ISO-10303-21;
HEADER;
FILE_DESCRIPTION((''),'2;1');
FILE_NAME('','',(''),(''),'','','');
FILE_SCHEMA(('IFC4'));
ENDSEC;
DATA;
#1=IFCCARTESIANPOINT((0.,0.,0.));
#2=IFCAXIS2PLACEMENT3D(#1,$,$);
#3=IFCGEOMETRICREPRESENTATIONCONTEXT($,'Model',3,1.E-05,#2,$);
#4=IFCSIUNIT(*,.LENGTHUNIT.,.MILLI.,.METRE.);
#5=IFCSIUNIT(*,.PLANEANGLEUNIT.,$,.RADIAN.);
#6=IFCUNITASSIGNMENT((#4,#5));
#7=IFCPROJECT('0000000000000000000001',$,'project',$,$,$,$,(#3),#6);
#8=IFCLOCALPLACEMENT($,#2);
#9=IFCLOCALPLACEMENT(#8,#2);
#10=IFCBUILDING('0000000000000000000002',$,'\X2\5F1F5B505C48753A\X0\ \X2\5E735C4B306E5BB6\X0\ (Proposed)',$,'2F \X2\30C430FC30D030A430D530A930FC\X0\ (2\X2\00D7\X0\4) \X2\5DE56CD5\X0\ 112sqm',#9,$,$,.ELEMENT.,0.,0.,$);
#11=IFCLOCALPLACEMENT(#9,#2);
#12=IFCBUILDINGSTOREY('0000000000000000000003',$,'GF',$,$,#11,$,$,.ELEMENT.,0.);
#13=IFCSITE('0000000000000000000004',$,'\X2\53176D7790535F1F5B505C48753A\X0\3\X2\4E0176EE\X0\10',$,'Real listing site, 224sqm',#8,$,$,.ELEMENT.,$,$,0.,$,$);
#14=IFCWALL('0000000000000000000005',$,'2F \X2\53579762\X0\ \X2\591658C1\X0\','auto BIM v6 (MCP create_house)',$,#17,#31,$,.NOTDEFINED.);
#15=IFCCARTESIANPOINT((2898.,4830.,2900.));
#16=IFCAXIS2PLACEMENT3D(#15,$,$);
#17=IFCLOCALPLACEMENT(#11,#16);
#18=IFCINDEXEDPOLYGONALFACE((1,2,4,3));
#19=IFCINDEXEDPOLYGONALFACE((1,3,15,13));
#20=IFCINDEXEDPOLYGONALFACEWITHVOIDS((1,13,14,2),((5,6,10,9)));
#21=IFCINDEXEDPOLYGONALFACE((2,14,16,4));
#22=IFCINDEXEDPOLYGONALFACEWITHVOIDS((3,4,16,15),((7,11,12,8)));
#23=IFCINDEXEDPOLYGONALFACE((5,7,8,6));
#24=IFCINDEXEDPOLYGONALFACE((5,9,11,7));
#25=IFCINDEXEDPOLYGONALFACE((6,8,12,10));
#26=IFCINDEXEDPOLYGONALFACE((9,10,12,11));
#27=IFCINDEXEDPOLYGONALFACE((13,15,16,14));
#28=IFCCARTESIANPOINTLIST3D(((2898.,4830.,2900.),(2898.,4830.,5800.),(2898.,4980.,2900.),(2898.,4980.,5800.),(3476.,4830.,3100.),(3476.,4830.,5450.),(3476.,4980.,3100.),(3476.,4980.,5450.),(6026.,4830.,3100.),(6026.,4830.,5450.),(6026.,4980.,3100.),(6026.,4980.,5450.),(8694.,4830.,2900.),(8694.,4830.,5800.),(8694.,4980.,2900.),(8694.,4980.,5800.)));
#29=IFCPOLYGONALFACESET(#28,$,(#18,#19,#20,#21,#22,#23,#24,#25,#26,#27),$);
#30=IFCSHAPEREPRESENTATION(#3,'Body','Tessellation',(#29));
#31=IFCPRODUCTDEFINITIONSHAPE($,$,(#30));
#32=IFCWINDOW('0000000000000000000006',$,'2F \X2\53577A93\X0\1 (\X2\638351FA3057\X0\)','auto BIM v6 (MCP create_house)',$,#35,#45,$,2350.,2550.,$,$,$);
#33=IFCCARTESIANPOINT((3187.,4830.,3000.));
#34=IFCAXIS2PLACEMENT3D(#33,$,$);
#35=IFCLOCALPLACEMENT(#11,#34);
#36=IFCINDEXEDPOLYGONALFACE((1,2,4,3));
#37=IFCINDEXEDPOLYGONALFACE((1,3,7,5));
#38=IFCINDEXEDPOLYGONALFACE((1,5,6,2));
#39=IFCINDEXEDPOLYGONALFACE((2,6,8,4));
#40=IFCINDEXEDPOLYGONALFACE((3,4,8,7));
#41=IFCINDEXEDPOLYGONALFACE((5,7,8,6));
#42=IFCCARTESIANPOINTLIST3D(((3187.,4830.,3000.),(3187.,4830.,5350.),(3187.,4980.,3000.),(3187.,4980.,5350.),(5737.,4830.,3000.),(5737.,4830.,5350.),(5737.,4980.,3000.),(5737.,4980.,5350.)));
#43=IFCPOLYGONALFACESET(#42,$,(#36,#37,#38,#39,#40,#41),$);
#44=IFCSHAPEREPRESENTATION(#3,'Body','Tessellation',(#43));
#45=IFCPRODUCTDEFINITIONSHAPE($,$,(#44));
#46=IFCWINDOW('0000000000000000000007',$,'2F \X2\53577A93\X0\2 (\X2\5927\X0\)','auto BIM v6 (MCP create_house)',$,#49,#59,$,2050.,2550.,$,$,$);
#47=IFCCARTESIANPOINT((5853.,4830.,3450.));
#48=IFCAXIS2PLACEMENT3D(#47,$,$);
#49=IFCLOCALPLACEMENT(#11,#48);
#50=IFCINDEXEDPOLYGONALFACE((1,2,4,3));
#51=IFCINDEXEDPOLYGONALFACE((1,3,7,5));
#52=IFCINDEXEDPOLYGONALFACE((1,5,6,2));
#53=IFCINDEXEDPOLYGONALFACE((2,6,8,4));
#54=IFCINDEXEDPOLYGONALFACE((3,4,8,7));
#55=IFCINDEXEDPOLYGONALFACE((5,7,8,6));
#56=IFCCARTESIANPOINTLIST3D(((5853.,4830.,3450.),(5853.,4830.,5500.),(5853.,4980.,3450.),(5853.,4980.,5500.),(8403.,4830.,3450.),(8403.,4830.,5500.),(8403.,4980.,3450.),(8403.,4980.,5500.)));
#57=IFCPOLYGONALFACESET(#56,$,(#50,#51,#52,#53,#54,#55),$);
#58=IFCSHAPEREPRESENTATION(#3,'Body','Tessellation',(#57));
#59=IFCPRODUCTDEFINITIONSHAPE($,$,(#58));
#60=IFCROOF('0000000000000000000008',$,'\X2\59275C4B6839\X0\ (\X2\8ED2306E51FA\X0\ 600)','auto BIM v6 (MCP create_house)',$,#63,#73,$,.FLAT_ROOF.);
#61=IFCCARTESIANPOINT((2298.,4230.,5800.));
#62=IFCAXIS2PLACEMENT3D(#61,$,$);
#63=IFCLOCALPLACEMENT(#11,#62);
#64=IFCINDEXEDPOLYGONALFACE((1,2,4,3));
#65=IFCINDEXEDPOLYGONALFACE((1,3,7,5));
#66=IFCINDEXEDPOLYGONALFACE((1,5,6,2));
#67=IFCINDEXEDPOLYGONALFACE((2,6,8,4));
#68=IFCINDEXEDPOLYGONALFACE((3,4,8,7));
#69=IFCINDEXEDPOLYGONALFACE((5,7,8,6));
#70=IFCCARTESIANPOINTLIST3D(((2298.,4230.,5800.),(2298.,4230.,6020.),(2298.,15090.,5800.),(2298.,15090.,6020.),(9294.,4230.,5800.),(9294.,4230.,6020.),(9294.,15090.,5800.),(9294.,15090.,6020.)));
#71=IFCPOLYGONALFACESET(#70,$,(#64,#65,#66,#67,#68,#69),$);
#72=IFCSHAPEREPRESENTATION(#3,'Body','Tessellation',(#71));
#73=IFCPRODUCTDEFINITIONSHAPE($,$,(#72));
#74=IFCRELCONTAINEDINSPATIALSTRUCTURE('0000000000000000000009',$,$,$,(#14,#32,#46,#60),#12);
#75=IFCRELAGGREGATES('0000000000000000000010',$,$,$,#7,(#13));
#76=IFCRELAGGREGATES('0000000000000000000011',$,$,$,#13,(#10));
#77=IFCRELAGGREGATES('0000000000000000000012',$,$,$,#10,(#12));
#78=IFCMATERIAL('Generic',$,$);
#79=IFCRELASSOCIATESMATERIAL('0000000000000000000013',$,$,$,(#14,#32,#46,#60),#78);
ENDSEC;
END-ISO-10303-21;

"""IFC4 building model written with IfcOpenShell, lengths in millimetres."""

from ifc_helpers import new_model, si_unit, frame, frame_2d, origin, place, context, project, spatial, rectangle, extrude, material, element, fill, save


model = new_model("IFC4")

# Units and contexts
model_context = context("Model", 3, precision=1e-05, world=origin())
ifc_project = project(units=[si_unit("LENGTHUNIT", "METRE", prefix="MILLI"), si_unit("PLANEANGLEUNIT", "RADIAN")], contexts=[model_context])

# Site, building, storey
site_placement = place(None, origin())
site = spatial("IfcSite", under=ifc_project, at=site_placement, Name="北海道弟子屈町3丁目10", ObjectType="Real listing site, 224sqm", CompositionType="ELEMENT", RefElevation=0.0)
building_placement = place(site_placement, origin())
building = spatial("IfcBuilding", under=site, at=building_placement, Name="弟子屈町 平屋の家 (Proposed)", ObjectType="2F ツーバイフォー (2×4) 工法 112sqm", CompositionType="ELEMENT", ElevationOfRefHeight=0.0, ElevationOfTerrain=0.0)
storey_placement = place(building_placement, origin())
storey = spatial("IfcBuildingStorey", under=building, at=storey_placement, Name="GF", CompositionType="ELEMENT", Elevation=0.0)

# Shared definitions
ifc_material = material(Name="Generic")

# Wall, openings, windows
wall_1_placement = place(storey_placement, frame((2898.0, 4830.0, 2900.0)))
wall_1 = element("IfcWall", 1, at=wall_1_placement, inside=storey, material=ifc_material, Name="2F 南面 外壁", Description="auto BIM v6 (MCP create_house)", PredefinedType="NOTDEFINED", context=model_context, shape_type="SweptSolid", body=[
    extrude(rectangle(XDim=5796.0, YDim=150.0, at=frame_2d((2898.0, 75.0))), frame((2898.0, 4830.0, 2900.0)), (0.0, 0.0, 1.0), 2900.0),
])
opening_1_placement = place(storey_placement, frame((3187.0, 4830.0, 3000.0)))
opening_1 = element("IfcOpeningElement", 2, at=opening_1_placement, cuts=wall_1, PredefinedType="NOTDEFINED", context=model_context, shape_type="SweptSolid", body=[
    extrude(rectangle(XDim=2550.0, YDim=150.0, at=frame_2d((1275.0, 75.0))), frame((3187.0, 4830.0, 3000.0)), (0.0, 0.0, 1.0), 2350.0),
])
opening_2_placement = place(storey_placement, frame((5853.0, 4830.0, 3450.0)))
opening_2 = element("IfcOpeningElement", 3, at=opening_2_placement, cuts=wall_1, PredefinedType="NOTDEFINED", context=model_context, shape_type="SweptSolid", body=[
    extrude(rectangle(XDim=2550.0, YDim=150.0, at=frame_2d((1275.0, 75.0))), frame((5853.0, 4830.0, 3450.0)), (0.0, 0.0, 1.0), 2050.0),
])
window_1_placement = place(storey_placement, frame((3187.0, 4830.0, 3000.0)))
window_1 = element("IfcWindow", 4, at=window_1_placement, inside=storey, material=ifc_material, Name="2F 南窓1 (掃出し)", Description="auto BIM v6 (MCP create_house)", OverallHeight=2350.0, OverallWidth=2550.0, context=model_context, shape_type="SweptSolid", body=[
    extrude(rectangle(XDim=2550.0, YDim=150.0, at=frame_2d((1275.0, 75.0))), frame((3187.0, 4830.0, 3000.0)), (0.0, 0.0, 1.0), 2350.0),
])
fill(opening_1, window_1)
window_2_placement = place(storey_placement, frame((5853.0, 4830.0, 3450.0)))
window_2 = element("IfcWindow", 5, at=window_2_placement, inside=storey, material=ifc_material, Name="2F 南窓2 (大)", Description="auto BIM v6 (MCP create_house)", OverallHeight=2050.0, OverallWidth=2550.0, context=model_context, shape_type="SweptSolid", body=[
    extrude(rectangle(XDim=2550.0, YDim=150.0, at=frame_2d((1275.0, 75.0))), frame((5853.0, 4830.0, 3450.0)), (0.0, 0.0, 1.0), 2050.0),
])
fill(opening_2, window_2)

# Roof
roof_placement = place(storey_placement, frame((2298.0, 4230.0, 5800.0)))
element("IfcRoof", 6, at=roof_placement, inside=storey, material=ifc_material, Name="大屋根 (軒の出 600)", Description="auto BIM v6 (MCP create_house)", PredefinedType="FLAT_ROOF", context=model_context, shape_type="SweptSolid", body=[
    extrude(rectangle(XDim=6996.0, YDim=10860.0, at=frame_2d((3498.0, 5430.0))), frame((2298.0, 4230.0, 5800.0)), (0.0, 0.0, 1.0), 220.0),
])

save(model, "model.ifc")
